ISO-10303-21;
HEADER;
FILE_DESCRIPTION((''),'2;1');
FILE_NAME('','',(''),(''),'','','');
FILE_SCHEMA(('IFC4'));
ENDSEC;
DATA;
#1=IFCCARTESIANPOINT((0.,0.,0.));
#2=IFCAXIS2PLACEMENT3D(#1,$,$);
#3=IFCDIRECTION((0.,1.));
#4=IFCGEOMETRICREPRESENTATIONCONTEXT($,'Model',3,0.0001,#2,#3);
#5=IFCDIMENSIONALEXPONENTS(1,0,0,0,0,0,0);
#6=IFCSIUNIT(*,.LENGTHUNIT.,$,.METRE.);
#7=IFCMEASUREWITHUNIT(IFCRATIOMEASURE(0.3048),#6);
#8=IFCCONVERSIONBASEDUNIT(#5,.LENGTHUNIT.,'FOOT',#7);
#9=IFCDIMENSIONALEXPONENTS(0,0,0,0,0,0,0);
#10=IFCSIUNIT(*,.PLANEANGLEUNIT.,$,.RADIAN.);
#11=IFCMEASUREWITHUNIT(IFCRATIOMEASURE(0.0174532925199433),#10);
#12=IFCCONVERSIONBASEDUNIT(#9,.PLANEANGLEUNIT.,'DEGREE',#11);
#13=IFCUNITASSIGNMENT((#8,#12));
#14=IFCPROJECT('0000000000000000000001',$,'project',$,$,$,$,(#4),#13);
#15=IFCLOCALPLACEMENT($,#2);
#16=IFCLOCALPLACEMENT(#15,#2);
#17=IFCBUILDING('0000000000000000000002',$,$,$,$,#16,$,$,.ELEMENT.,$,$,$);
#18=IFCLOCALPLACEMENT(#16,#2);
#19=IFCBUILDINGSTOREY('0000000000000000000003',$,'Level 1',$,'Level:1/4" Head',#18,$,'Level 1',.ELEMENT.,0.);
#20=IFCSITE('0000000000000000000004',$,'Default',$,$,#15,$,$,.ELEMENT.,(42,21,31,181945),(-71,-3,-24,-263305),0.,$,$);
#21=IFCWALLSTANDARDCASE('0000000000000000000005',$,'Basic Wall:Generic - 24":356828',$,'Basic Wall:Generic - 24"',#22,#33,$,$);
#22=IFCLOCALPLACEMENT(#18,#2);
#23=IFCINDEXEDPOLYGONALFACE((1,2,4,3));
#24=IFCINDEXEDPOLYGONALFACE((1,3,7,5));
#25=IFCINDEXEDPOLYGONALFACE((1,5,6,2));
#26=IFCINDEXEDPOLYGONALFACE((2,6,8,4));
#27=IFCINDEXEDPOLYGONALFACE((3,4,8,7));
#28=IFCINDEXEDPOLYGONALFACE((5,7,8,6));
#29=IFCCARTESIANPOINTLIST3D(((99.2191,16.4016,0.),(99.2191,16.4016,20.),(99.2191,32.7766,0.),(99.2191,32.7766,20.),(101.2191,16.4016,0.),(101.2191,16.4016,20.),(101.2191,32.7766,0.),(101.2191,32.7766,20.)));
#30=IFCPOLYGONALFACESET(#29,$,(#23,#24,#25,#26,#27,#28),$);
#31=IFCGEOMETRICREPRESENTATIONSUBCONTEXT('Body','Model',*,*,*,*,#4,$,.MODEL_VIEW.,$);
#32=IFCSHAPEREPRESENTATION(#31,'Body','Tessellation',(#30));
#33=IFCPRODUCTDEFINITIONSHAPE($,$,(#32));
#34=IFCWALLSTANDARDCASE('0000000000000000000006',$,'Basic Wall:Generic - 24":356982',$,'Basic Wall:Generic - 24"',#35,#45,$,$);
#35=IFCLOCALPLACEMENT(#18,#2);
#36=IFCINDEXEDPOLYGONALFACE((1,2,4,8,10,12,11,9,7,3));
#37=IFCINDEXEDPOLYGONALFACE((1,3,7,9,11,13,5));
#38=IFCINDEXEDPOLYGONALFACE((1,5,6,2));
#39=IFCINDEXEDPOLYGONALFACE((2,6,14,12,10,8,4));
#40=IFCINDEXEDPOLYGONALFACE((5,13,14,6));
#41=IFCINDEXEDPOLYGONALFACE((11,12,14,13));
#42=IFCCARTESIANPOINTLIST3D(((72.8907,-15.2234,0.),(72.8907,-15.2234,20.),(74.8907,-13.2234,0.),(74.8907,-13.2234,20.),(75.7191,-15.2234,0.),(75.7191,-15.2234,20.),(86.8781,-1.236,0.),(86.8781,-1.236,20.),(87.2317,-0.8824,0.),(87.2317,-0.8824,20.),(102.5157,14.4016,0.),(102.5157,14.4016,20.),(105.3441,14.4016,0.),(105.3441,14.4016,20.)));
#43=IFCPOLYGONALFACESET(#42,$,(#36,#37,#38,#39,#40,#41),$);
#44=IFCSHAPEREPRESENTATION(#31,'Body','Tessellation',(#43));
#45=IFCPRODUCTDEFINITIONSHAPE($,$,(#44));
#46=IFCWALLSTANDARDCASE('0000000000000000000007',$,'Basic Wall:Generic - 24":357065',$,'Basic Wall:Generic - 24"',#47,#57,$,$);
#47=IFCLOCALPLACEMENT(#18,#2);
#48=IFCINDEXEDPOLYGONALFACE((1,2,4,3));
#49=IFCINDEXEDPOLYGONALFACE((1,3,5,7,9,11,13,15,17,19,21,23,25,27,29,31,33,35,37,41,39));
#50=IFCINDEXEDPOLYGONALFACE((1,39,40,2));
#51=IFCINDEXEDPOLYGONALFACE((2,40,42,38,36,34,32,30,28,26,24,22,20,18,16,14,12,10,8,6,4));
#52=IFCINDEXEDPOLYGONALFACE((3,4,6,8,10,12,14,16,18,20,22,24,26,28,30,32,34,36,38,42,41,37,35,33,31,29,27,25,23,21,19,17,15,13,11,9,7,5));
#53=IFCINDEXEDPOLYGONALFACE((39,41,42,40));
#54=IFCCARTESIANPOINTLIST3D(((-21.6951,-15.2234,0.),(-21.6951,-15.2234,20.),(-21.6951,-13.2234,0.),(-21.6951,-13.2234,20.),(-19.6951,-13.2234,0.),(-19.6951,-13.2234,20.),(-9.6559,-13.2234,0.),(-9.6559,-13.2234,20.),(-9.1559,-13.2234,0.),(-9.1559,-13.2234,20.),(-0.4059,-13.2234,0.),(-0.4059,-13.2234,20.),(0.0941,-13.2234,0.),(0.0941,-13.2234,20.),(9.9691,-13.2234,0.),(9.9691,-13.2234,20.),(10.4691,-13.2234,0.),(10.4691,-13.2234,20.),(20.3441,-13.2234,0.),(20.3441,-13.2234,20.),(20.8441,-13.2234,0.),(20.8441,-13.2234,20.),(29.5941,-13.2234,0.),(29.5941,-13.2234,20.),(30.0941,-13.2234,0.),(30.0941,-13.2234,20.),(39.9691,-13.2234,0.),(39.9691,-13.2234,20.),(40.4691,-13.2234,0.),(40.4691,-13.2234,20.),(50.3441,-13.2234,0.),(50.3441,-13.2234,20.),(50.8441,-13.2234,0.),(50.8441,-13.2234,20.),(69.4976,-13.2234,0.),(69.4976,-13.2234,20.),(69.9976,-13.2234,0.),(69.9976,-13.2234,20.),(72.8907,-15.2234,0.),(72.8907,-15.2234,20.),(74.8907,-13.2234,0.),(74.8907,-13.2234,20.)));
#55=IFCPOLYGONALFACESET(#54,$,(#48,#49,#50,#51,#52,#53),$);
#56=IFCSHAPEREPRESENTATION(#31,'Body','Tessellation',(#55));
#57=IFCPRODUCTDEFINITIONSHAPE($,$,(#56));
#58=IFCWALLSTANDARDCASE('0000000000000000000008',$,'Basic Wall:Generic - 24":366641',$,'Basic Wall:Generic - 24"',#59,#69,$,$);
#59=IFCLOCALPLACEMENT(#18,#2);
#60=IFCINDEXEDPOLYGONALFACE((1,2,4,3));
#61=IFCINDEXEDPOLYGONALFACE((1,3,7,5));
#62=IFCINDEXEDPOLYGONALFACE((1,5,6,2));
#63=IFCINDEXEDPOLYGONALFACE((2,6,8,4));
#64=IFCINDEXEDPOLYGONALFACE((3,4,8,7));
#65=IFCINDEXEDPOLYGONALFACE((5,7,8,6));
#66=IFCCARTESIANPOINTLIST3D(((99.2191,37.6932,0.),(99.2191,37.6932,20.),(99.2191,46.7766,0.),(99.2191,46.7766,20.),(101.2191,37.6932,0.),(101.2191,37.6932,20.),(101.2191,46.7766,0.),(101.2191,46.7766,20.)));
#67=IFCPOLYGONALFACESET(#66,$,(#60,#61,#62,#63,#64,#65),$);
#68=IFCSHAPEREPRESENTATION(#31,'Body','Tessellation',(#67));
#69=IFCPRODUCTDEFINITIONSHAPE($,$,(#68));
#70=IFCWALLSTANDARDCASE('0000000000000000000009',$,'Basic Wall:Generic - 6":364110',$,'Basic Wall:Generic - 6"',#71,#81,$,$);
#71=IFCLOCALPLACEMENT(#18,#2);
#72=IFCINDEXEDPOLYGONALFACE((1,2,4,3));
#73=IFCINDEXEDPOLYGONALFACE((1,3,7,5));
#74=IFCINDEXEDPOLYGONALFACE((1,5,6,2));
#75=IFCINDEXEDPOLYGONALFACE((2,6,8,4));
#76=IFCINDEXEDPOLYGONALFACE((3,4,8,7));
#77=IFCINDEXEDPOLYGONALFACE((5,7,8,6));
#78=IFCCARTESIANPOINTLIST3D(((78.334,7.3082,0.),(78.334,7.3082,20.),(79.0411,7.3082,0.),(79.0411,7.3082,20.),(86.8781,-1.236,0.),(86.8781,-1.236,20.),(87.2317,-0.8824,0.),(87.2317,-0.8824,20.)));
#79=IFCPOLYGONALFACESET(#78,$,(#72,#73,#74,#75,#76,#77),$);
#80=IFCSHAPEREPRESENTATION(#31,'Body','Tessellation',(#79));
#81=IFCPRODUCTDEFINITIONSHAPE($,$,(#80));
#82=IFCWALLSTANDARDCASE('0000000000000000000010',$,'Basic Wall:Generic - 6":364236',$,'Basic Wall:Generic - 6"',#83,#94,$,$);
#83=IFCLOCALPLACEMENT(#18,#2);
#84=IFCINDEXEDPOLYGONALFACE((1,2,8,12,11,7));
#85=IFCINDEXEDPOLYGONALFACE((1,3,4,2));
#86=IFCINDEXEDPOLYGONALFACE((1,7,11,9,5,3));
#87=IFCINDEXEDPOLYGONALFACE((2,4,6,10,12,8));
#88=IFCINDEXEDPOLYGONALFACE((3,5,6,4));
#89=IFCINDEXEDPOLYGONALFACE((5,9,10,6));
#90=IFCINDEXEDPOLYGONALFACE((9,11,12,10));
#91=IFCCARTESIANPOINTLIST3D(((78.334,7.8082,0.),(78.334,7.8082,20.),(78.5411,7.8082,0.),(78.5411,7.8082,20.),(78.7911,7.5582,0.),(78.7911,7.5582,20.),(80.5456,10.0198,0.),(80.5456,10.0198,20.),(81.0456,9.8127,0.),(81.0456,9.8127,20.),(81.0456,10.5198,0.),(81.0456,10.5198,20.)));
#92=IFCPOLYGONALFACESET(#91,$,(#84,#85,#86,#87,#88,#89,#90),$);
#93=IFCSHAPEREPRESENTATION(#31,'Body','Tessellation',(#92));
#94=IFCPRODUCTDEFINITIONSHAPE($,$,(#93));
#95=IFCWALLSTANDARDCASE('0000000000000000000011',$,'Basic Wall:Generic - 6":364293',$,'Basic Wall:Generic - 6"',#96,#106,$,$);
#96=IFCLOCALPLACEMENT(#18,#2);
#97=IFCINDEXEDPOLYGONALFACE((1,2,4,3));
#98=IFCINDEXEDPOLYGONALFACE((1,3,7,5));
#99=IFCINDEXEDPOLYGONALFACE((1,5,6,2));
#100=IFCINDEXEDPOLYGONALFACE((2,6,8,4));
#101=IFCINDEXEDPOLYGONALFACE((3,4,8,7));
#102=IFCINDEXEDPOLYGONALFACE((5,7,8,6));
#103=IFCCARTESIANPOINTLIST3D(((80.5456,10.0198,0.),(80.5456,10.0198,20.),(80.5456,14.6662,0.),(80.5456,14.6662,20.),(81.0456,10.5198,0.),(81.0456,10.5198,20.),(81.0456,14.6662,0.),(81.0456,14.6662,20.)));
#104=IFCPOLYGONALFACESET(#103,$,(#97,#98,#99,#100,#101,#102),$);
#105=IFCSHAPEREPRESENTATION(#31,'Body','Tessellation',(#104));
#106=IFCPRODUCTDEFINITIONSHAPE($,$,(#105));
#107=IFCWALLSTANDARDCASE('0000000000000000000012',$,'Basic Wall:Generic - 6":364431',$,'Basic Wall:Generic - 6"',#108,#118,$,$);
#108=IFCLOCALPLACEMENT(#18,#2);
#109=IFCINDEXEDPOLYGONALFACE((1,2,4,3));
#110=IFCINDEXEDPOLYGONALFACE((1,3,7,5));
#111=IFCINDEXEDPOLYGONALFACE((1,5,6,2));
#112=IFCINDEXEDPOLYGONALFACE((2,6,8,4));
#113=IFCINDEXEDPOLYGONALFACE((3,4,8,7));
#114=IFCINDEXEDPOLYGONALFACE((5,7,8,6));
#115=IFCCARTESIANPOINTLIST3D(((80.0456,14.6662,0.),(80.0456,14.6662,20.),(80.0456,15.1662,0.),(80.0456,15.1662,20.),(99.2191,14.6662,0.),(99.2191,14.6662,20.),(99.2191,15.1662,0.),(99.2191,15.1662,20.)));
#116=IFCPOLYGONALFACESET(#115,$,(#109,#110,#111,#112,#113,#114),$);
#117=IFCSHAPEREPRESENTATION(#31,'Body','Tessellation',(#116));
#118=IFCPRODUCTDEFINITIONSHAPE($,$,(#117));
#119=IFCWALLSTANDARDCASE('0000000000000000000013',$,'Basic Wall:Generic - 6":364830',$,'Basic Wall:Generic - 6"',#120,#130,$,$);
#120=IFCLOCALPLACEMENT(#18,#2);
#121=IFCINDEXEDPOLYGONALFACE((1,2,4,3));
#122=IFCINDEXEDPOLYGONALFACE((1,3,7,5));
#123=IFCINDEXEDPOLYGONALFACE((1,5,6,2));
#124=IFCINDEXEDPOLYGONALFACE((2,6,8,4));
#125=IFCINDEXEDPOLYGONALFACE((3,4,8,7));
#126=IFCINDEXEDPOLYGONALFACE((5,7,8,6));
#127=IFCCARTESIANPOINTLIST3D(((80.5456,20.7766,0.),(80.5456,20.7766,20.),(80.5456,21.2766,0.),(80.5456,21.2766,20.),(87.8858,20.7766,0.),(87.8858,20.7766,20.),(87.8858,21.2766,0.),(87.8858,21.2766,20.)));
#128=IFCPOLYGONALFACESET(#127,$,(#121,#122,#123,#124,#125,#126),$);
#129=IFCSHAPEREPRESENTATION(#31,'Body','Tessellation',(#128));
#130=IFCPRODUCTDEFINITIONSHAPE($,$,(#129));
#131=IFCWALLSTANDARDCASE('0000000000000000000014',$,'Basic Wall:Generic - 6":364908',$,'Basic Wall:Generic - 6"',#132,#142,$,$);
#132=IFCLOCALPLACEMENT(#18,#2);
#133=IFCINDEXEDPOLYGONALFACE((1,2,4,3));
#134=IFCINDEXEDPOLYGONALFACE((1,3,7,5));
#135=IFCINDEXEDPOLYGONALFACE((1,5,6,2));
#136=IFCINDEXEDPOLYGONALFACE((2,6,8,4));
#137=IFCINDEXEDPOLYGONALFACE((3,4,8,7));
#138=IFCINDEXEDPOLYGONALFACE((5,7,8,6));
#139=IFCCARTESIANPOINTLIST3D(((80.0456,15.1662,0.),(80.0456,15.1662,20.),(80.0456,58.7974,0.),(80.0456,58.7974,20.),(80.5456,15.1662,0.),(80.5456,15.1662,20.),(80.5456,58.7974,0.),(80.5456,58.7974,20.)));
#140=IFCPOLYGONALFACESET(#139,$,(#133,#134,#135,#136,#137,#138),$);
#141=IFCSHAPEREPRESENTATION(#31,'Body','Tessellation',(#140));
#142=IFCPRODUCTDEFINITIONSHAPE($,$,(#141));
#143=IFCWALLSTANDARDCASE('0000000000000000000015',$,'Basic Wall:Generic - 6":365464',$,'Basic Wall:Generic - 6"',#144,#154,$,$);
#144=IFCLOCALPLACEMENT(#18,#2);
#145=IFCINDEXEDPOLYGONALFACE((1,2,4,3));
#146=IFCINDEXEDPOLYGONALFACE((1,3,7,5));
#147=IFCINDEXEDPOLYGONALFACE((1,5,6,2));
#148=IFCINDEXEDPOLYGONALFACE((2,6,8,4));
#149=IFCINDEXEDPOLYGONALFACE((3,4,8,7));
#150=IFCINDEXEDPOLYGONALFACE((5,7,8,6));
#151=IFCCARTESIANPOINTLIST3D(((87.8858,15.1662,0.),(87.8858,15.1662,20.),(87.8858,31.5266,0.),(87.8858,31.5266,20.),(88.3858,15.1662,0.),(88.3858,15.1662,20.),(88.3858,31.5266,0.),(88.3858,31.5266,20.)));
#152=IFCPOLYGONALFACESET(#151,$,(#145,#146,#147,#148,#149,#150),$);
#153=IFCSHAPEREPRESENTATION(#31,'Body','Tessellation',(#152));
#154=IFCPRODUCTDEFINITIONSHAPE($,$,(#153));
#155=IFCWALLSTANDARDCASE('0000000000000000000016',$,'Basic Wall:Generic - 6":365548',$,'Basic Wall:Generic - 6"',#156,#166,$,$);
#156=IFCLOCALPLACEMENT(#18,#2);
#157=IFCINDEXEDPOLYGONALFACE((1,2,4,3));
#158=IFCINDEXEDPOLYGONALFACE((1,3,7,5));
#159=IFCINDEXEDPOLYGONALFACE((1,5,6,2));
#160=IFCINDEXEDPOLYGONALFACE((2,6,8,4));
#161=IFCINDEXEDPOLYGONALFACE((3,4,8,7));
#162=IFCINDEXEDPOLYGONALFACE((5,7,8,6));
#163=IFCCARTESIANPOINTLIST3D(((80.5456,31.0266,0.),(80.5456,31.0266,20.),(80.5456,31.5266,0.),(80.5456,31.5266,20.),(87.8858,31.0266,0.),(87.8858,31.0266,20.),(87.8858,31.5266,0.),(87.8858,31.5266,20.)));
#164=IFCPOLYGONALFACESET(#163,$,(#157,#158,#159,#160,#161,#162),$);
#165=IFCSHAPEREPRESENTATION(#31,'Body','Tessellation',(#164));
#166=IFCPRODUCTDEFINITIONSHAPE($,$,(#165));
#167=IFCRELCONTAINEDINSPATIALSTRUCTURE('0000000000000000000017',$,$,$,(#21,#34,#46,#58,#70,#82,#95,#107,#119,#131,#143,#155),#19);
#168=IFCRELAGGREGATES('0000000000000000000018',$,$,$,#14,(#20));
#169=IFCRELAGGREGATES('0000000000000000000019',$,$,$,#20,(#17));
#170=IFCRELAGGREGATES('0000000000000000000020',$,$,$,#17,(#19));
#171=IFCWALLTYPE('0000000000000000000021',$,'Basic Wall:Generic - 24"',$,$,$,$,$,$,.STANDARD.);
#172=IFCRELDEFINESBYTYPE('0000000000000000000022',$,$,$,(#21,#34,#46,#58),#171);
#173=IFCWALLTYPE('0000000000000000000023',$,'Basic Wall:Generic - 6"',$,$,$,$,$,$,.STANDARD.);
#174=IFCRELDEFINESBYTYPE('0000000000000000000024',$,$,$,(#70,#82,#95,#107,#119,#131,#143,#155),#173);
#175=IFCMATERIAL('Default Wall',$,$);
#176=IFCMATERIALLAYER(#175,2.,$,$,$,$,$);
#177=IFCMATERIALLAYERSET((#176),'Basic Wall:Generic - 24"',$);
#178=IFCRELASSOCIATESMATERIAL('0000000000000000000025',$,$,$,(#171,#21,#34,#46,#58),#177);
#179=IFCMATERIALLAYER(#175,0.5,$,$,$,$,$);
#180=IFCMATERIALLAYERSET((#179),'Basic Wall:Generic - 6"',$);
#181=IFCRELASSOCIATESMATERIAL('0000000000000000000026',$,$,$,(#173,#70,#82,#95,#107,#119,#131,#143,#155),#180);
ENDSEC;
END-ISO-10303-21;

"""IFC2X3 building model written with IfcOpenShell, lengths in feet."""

from ifc_helpers import new_model, entity, si_unit, converted_unit, direction, frame, frame_2d, origin, place, context, subcontext, project, spatial, polyline, rectangle, outline, extrude, material, layer, layer_set, layer_usage, type_object, element, save


model = new_model("IFC2X3")

# Units and contexts
model_context = context("Model", 3, precision=0.0001, world=origin(), true_north=direction((0.0, 1.0)))
body_context = subcontext(model_context, "Body", "Model", "MODEL_VIEW")
ifc_project = project(units=[converted_unit("LENGTHUNIT", "FOOT", entity("IfcRatioMeasure", 0.3048), si_unit("LENGTHUNIT", "METRE"), dimensions=[1, 0, 0, 0, 0, 0, 0]), converted_unit("PLANEANGLEUNIT", "DEGREE", entity("IfcRatioMeasure", 0.0174532925199433), si_unit("PLANEANGLEUNIT", "RADIAN"), dimensions=[0, 0, 0, 0, 0, 0, 0])], contexts=[model_context])

# Site, building, storey
site_placement = place(None, origin())
site = spatial("IfcSite", under=ifc_project, at=site_placement, Name="Default", CompositionType="ELEMENT", RefLatitude=(42, 21, 31, 181945), RefLongitude=(-71, -3, -24, -263305), RefElevation=0.0)
building_placement = place(site_placement, origin())
building = spatial("IfcBuilding", under=site, at=building_placement, CompositionType="ELEMENT")
storey_placement = place(building_placement, origin())
storey = spatial("IfcBuildingStorey", under=building, at=storey_placement, Name="Level 1", ObjectType="Level:1/4\" Head", LongName="Level 1", CompositionType="ELEMENT", Elevation=0.0)

# Walls
ifc_material = material(Name="Default Wall")
ifc_layer_1 = layer(ifc_material, 2.0)
ifc_layer_set_1 = layer_set([ifc_layer_1], Name="Basic Wall:Generic - 24\"")
ifc_layer_usage_1 = layer_usage(ifc_layer_set_1, "AXIS2", "NEGATIVE", 1.0)
wall_type_1 = type_object("IfcWallType", Name="Basic Wall:Generic - 24\"", PredefinedType="STANDARD", material=ifc_layer_set_1)
wall_1_placement = place(storey_placement, frame((100.2191, 16.4016, 0.0), z_axis=(0.0, 0.0, 1.0), x_axis=(0.0, 1.0, 0.0)))
element("IfcWallStandardCase", 1, at=wall_1_placement, inside=storey, type_object=wall_type_1, material=ifc_layer_usage_1, Name="Basic Wall:Generic - 24\":356828", ObjectType="Basic Wall:Generic - 24\"", context=body_context, shape_type="SweptSolid", body=[
    extrude(rectangle(XDim=16.375, YDim=2.0, at=frame_2d((8.1875, 0.0), x_axis=(-1.0, 0.0))), origin(), (0.0, 0.0, 1.0), 20.0),
])
ifc_layer_usage_2 = layer_usage(ifc_layer_set_1, "AXIS2", "NEGATIVE", 1.0)
wall_2_placement = place(storey_placement, frame((73.5978, -15.9305, 0.0), z_axis=(0.0, 0.0, 1.0), x_axis=(0.707107, 0.707107, 0.0)))
element("IfcWallStandardCase", 2, at=wall_2_placement, inside=storey, type_object=wall_type_1, material=ifc_layer_usage_2, Name="Basic Wall:Generic - 24\":356982", ObjectType="Basic Wall:Generic - 24\"", context=body_context, shape_type="SweptSolid", body=[
    extrude(outline(polyline([(43.8961, -1.0), (41.8961, 1.0), (20.2812, 1.0), (19.7812, 1.0), (2.8284, 1.0), (0.0, 1.0), (2.0, -1.0), (43.8961, -1.0)])), origin(), (0.0, 0.0, 1.0), 20.0),
])
ifc_layer_usage_3 = layer_usage(ifc_layer_set_1, "AXIS2", "NEGATIVE", 1.0)
wall_3_placement = place(storey_placement, frame((74.8907, -14.2234, 0.0), z_axis=(0.0, 0.0, 1.0), x_axis=(-1.0, 0.0, 0.0)))
element("IfcWallStandardCase", 3, at=wall_3_placement, inside=storey, type_object=wall_type_1, material=ifc_layer_usage_3, Name="Basic Wall:Generic - 24\":357065", ObjectType="Basic Wall:Generic - 24\"", context=body_context, shape_type="SweptSolid", body=[
    extrude(outline(polyline([(96.5858, -1.0), (96.5858, 1.0), (2.0, 1.0), (0.0, -1.0), (4.8931, -1.0), (5.3931, -1.0), (24.0466, -1.0), (24.5466, -1.0), (34.4216, -1.0), (34.9216, -1.0), (44.7966, -1.0), (45.2966, -1.0), (54.0466, -1.0), (54.5466, -1.0), (64.4216, -1.0), (64.9216, -1.0), (74.7966, -1.0), (75.2966, -1.0), (84.0466, -1.0), (84.5466, -1.0), (94.5858, -1.0), (96.5858, -1.0)])), origin(), (0.0, 0.0, 1.0), 20.0),
])
ifc_layer_usage_4 = layer_usage(ifc_layer_set_1, "AXIS2", "NEGATIVE", 1.0)
wall_4_placement = place(storey_placement, frame((100.2191, 46.7766, 0.0), z_axis=(0.0, 0.0, 1.0), x_axis=(0.0, -1.0, 0.0)))
element("IfcWallStandardCase", 4, at=wall_4_placement, inside=storey, type_object=wall_type_1, material=ifc_layer_usage_4, Name="Basic Wall:Generic - 24\":366641", ObjectType="Basic Wall:Generic - 24\"", context=body_context, shape_type="SweptSolid", body=[
    extrude(rectangle(XDim=9.0833, YDim=2.0, at=frame_2d((4.5417, 0.0), x_axis=(-1.0, 0.0))), origin(), (0.0, 0.0, 1.0), 20.0),
])
ifc_layer_2 = layer(ifc_material, 0.5)
ifc_layer_set_2 = layer_set([ifc_layer_2], Name="Basic Wall:Generic - 6\"")
ifc_layer_usage_5 = layer_usage(ifc_layer_set_2, "AXIS2", "NEGATIVE", 0.25)
wall_type_2 = type_object("IfcWallType", Name="Basic Wall:Generic - 6\"", PredefinedType="STANDARD", material=ifc_layer_set_2)
wall_5_placement = place(storey_placement, frame((78.5108, 7.4849, 0.0), z_axis=(0.0, 0.0, 1.0), x_axis=(0.707107, -0.707107, 0.0)))
element("IfcWallStandardCase", 5, at=wall_5_placement, inside=storey, type_object=wall_type_2, material=ifc_layer_usage_5, Name="Basic Wall:Generic - 6\":364110", ObjectType="Basic Wall:Generic - 6\"", context=body_context, shape_type="SweptSolid", body=[
    extrude(outline(polyline([(12.0832, -0.25), (12.0832, 0.25), (0.5, 0.25), (0.0, -0.25), (12.0832, -0.25)])), origin(), (0.0, 0.0, 1.0), 20.0),
])
ifc_layer_usage_6 = layer_usage(ifc_layer_set_2, "AXIS2", "NEGATIVE", 0.25)
wall_6_placement = place(storey_placement, frame((78.5108, 7.6314, 0.0), z_axis=(0.0, 0.0, 1.0), x_axis=(0.707107, 0.707107, 0.0)))
element("IfcWallStandardCase", 6, at=wall_6_placement, inside=storey, type_object=wall_type_2, material=ifc_layer_usage_6, Name="Basic Wall:Generic - 6\":364236", ObjectType="Basic Wall:Generic - 6\"", context=body_context, shape_type="SweptSolid", body=[
    extrude(outline(polyline([(3.3348, -0.25), (3.8348, 0.25), (3.1277, 0.25), (0.0, 0.25), (0.1464, 0.1036), (0.1464, -0.25), (3.3348, -0.25)])), origin(), (0.0, 0.0, 1.0), 20.0),
])
ifc_layer_usage_7 = layer_usage(ifc_layer_set_2, "AXIS2", "NEGATIVE", 0.25)
wall_7_placement = place(storey_placement, frame((80.7956, 10.0198, 0.0), z_axis=(0.0, 0.0, 1.0), x_axis=(0.0, 1.0, 0.0)))
element("IfcWallStandardCase", 7, at=wall_7_placement, inside=storey, type_object=wall_type_2, material=ifc_layer_usage_7, Name="Basic Wall:Generic - 6\":364293", ObjectType="Basic Wall:Generic - 6\"", context=body_context, shape_type="SweptSolid", body=[
    extrude(outline(polyline([(4.6464, -0.25), (4.6464, 0.25), (0.0, 0.25), (0.5, -0.25), (4.6464, -0.25)])), origin(), (0.0, 0.0, 1.0), 20.0),
])
ifc_layer_usage_8 = layer_usage(ifc_layer_set_2, "AXIS2", "NEGATIVE", 0.25)
wall_8_placement = place(storey_placement, frame((99.2191, 14.9162, 0.0), z_axis=(0.0, 0.0, 1.0), x_axis=(-1.0, 0.0, 0.0)))
element("IfcWallStandardCase", 8, at=wall_8_placement, inside=storey, type_object=wall_type_2, material=ifc_layer_usage_8, Name="Basic Wall:Generic - 6\":364431", ObjectType="Basic Wall:Generic - 6\"", context=body_context, shape_type="SweptSolid", body=[
    extrude(rectangle(XDim=19.1735, YDim=0.5, at=frame_2d((9.5868, 0.0), x_axis=(-1.0, 0.0))), origin(), (0.0, 0.0, 1.0), 20.0),
])
ifc_layer_usage_9 = layer_usage(ifc_layer_set_2, "AXIS2", "NEGATIVE", 0.25)
wall_9_placement = place(storey_placement, frame((87.8858, 21.0266, 0.0), z_axis=(0.0, 0.0, 1.0), x_axis=(-1.0, 0.0, 0.0)))
element("IfcWallStandardCase", 9, at=wall_9_placement, inside=storey, type_object=wall_type_2, material=ifc_layer_usage_9, Name="Basic Wall:Generic - 6\":364830", ObjectType="Basic Wall:Generic - 6\"", context=body_context, shape_type="SweptSolid", body=[
    extrude(rectangle(XDim=7.3402, YDim=0.5, at=frame_2d((3.6701, 0.0), x_axis=(-1.0, 0.0))), origin(), (0.0, 0.0, 1.0), 20.0),
])
ifc_layer_usage_10 = layer_usage(ifc_layer_set_2, "AXIS2", "NEGATIVE", 0.25)
wall_10_placement = place(storey_placement, frame((80.2956, 58.7974, 0.0), z_axis=(0.0, 0.0, 1.0), x_axis=(0.0, -1.0, 0.0)))
element("IfcWallStandardCase", 10, at=wall_10_placement, inside=storey, type_object=wall_type_2, material=ifc_layer_usage_10, Name="Basic Wall:Generic - 6\":364908", ObjectType="Basic Wall:Generic - 6\"", context=body_context, shape_type="SweptSolid", body=[
    extrude(rectangle(XDim=43.6312, YDim=0.5, at=frame_2d((21.8156, 0.0), x_axis=(-1.0, 0.0))), origin(), (0.0, 0.0, 1.0), 20.0),
])
ifc_layer_usage_11 = layer_usage(ifc_layer_set_2, "AXIS2", "NEGATIVE", 0.25)
wall_11_placement = place(storey_placement, frame((88.1358, 15.1662, 0.0), z_axis=(0.0, 0.0, 1.0), x_axis=(0.0, 1.0, 0.0)))
element("IfcWallStandardCase", 11, at=wall_11_placement, inside=storey, type_object=wall_type_2, material=ifc_layer_usage_11, Name="Basic Wall:Generic - 6\":365464", ObjectType="Basic Wall:Generic - 6\"", context=body_context, shape_type="SweptSolid", body=[
    extrude(rectangle(XDim=16.3604, YDim=0.5, at=frame_2d((8.1802, 0.0), x_axis=(-1.0, 0.0))), origin(), (0.0, 0.0, 1.0), 20.0),
])
ifc_layer_usage_12 = layer_usage(ifc_layer_set_2, "AXIS2", "NEGATIVE", 0.25)
wall_12_placement = place(storey_placement, frame((87.8858, 31.2766, 0.0), z_axis=(0.0, 0.0, 1.0), x_axis=(-1.0, 0.0, 0.0)))
element("IfcWallStandardCase", 12, at=wall_12_placement, inside=storey, type_object=wall_type_2, material=ifc_layer_usage_12, Name="Basic Wall:Generic - 6\":365548", ObjectType="Basic Wall:Generic - 6\"", context=body_context, shape_type="SweptSolid", body=[
    extrude(rectangle(XDim=7.3402, YDim=0.5, at=frame_2d((3.6701, 0.0), x_axis=(-1.0, 0.0))), origin(), (0.0, 0.0, 1.0), 20.0),
])

save(model, "model.ifc")
